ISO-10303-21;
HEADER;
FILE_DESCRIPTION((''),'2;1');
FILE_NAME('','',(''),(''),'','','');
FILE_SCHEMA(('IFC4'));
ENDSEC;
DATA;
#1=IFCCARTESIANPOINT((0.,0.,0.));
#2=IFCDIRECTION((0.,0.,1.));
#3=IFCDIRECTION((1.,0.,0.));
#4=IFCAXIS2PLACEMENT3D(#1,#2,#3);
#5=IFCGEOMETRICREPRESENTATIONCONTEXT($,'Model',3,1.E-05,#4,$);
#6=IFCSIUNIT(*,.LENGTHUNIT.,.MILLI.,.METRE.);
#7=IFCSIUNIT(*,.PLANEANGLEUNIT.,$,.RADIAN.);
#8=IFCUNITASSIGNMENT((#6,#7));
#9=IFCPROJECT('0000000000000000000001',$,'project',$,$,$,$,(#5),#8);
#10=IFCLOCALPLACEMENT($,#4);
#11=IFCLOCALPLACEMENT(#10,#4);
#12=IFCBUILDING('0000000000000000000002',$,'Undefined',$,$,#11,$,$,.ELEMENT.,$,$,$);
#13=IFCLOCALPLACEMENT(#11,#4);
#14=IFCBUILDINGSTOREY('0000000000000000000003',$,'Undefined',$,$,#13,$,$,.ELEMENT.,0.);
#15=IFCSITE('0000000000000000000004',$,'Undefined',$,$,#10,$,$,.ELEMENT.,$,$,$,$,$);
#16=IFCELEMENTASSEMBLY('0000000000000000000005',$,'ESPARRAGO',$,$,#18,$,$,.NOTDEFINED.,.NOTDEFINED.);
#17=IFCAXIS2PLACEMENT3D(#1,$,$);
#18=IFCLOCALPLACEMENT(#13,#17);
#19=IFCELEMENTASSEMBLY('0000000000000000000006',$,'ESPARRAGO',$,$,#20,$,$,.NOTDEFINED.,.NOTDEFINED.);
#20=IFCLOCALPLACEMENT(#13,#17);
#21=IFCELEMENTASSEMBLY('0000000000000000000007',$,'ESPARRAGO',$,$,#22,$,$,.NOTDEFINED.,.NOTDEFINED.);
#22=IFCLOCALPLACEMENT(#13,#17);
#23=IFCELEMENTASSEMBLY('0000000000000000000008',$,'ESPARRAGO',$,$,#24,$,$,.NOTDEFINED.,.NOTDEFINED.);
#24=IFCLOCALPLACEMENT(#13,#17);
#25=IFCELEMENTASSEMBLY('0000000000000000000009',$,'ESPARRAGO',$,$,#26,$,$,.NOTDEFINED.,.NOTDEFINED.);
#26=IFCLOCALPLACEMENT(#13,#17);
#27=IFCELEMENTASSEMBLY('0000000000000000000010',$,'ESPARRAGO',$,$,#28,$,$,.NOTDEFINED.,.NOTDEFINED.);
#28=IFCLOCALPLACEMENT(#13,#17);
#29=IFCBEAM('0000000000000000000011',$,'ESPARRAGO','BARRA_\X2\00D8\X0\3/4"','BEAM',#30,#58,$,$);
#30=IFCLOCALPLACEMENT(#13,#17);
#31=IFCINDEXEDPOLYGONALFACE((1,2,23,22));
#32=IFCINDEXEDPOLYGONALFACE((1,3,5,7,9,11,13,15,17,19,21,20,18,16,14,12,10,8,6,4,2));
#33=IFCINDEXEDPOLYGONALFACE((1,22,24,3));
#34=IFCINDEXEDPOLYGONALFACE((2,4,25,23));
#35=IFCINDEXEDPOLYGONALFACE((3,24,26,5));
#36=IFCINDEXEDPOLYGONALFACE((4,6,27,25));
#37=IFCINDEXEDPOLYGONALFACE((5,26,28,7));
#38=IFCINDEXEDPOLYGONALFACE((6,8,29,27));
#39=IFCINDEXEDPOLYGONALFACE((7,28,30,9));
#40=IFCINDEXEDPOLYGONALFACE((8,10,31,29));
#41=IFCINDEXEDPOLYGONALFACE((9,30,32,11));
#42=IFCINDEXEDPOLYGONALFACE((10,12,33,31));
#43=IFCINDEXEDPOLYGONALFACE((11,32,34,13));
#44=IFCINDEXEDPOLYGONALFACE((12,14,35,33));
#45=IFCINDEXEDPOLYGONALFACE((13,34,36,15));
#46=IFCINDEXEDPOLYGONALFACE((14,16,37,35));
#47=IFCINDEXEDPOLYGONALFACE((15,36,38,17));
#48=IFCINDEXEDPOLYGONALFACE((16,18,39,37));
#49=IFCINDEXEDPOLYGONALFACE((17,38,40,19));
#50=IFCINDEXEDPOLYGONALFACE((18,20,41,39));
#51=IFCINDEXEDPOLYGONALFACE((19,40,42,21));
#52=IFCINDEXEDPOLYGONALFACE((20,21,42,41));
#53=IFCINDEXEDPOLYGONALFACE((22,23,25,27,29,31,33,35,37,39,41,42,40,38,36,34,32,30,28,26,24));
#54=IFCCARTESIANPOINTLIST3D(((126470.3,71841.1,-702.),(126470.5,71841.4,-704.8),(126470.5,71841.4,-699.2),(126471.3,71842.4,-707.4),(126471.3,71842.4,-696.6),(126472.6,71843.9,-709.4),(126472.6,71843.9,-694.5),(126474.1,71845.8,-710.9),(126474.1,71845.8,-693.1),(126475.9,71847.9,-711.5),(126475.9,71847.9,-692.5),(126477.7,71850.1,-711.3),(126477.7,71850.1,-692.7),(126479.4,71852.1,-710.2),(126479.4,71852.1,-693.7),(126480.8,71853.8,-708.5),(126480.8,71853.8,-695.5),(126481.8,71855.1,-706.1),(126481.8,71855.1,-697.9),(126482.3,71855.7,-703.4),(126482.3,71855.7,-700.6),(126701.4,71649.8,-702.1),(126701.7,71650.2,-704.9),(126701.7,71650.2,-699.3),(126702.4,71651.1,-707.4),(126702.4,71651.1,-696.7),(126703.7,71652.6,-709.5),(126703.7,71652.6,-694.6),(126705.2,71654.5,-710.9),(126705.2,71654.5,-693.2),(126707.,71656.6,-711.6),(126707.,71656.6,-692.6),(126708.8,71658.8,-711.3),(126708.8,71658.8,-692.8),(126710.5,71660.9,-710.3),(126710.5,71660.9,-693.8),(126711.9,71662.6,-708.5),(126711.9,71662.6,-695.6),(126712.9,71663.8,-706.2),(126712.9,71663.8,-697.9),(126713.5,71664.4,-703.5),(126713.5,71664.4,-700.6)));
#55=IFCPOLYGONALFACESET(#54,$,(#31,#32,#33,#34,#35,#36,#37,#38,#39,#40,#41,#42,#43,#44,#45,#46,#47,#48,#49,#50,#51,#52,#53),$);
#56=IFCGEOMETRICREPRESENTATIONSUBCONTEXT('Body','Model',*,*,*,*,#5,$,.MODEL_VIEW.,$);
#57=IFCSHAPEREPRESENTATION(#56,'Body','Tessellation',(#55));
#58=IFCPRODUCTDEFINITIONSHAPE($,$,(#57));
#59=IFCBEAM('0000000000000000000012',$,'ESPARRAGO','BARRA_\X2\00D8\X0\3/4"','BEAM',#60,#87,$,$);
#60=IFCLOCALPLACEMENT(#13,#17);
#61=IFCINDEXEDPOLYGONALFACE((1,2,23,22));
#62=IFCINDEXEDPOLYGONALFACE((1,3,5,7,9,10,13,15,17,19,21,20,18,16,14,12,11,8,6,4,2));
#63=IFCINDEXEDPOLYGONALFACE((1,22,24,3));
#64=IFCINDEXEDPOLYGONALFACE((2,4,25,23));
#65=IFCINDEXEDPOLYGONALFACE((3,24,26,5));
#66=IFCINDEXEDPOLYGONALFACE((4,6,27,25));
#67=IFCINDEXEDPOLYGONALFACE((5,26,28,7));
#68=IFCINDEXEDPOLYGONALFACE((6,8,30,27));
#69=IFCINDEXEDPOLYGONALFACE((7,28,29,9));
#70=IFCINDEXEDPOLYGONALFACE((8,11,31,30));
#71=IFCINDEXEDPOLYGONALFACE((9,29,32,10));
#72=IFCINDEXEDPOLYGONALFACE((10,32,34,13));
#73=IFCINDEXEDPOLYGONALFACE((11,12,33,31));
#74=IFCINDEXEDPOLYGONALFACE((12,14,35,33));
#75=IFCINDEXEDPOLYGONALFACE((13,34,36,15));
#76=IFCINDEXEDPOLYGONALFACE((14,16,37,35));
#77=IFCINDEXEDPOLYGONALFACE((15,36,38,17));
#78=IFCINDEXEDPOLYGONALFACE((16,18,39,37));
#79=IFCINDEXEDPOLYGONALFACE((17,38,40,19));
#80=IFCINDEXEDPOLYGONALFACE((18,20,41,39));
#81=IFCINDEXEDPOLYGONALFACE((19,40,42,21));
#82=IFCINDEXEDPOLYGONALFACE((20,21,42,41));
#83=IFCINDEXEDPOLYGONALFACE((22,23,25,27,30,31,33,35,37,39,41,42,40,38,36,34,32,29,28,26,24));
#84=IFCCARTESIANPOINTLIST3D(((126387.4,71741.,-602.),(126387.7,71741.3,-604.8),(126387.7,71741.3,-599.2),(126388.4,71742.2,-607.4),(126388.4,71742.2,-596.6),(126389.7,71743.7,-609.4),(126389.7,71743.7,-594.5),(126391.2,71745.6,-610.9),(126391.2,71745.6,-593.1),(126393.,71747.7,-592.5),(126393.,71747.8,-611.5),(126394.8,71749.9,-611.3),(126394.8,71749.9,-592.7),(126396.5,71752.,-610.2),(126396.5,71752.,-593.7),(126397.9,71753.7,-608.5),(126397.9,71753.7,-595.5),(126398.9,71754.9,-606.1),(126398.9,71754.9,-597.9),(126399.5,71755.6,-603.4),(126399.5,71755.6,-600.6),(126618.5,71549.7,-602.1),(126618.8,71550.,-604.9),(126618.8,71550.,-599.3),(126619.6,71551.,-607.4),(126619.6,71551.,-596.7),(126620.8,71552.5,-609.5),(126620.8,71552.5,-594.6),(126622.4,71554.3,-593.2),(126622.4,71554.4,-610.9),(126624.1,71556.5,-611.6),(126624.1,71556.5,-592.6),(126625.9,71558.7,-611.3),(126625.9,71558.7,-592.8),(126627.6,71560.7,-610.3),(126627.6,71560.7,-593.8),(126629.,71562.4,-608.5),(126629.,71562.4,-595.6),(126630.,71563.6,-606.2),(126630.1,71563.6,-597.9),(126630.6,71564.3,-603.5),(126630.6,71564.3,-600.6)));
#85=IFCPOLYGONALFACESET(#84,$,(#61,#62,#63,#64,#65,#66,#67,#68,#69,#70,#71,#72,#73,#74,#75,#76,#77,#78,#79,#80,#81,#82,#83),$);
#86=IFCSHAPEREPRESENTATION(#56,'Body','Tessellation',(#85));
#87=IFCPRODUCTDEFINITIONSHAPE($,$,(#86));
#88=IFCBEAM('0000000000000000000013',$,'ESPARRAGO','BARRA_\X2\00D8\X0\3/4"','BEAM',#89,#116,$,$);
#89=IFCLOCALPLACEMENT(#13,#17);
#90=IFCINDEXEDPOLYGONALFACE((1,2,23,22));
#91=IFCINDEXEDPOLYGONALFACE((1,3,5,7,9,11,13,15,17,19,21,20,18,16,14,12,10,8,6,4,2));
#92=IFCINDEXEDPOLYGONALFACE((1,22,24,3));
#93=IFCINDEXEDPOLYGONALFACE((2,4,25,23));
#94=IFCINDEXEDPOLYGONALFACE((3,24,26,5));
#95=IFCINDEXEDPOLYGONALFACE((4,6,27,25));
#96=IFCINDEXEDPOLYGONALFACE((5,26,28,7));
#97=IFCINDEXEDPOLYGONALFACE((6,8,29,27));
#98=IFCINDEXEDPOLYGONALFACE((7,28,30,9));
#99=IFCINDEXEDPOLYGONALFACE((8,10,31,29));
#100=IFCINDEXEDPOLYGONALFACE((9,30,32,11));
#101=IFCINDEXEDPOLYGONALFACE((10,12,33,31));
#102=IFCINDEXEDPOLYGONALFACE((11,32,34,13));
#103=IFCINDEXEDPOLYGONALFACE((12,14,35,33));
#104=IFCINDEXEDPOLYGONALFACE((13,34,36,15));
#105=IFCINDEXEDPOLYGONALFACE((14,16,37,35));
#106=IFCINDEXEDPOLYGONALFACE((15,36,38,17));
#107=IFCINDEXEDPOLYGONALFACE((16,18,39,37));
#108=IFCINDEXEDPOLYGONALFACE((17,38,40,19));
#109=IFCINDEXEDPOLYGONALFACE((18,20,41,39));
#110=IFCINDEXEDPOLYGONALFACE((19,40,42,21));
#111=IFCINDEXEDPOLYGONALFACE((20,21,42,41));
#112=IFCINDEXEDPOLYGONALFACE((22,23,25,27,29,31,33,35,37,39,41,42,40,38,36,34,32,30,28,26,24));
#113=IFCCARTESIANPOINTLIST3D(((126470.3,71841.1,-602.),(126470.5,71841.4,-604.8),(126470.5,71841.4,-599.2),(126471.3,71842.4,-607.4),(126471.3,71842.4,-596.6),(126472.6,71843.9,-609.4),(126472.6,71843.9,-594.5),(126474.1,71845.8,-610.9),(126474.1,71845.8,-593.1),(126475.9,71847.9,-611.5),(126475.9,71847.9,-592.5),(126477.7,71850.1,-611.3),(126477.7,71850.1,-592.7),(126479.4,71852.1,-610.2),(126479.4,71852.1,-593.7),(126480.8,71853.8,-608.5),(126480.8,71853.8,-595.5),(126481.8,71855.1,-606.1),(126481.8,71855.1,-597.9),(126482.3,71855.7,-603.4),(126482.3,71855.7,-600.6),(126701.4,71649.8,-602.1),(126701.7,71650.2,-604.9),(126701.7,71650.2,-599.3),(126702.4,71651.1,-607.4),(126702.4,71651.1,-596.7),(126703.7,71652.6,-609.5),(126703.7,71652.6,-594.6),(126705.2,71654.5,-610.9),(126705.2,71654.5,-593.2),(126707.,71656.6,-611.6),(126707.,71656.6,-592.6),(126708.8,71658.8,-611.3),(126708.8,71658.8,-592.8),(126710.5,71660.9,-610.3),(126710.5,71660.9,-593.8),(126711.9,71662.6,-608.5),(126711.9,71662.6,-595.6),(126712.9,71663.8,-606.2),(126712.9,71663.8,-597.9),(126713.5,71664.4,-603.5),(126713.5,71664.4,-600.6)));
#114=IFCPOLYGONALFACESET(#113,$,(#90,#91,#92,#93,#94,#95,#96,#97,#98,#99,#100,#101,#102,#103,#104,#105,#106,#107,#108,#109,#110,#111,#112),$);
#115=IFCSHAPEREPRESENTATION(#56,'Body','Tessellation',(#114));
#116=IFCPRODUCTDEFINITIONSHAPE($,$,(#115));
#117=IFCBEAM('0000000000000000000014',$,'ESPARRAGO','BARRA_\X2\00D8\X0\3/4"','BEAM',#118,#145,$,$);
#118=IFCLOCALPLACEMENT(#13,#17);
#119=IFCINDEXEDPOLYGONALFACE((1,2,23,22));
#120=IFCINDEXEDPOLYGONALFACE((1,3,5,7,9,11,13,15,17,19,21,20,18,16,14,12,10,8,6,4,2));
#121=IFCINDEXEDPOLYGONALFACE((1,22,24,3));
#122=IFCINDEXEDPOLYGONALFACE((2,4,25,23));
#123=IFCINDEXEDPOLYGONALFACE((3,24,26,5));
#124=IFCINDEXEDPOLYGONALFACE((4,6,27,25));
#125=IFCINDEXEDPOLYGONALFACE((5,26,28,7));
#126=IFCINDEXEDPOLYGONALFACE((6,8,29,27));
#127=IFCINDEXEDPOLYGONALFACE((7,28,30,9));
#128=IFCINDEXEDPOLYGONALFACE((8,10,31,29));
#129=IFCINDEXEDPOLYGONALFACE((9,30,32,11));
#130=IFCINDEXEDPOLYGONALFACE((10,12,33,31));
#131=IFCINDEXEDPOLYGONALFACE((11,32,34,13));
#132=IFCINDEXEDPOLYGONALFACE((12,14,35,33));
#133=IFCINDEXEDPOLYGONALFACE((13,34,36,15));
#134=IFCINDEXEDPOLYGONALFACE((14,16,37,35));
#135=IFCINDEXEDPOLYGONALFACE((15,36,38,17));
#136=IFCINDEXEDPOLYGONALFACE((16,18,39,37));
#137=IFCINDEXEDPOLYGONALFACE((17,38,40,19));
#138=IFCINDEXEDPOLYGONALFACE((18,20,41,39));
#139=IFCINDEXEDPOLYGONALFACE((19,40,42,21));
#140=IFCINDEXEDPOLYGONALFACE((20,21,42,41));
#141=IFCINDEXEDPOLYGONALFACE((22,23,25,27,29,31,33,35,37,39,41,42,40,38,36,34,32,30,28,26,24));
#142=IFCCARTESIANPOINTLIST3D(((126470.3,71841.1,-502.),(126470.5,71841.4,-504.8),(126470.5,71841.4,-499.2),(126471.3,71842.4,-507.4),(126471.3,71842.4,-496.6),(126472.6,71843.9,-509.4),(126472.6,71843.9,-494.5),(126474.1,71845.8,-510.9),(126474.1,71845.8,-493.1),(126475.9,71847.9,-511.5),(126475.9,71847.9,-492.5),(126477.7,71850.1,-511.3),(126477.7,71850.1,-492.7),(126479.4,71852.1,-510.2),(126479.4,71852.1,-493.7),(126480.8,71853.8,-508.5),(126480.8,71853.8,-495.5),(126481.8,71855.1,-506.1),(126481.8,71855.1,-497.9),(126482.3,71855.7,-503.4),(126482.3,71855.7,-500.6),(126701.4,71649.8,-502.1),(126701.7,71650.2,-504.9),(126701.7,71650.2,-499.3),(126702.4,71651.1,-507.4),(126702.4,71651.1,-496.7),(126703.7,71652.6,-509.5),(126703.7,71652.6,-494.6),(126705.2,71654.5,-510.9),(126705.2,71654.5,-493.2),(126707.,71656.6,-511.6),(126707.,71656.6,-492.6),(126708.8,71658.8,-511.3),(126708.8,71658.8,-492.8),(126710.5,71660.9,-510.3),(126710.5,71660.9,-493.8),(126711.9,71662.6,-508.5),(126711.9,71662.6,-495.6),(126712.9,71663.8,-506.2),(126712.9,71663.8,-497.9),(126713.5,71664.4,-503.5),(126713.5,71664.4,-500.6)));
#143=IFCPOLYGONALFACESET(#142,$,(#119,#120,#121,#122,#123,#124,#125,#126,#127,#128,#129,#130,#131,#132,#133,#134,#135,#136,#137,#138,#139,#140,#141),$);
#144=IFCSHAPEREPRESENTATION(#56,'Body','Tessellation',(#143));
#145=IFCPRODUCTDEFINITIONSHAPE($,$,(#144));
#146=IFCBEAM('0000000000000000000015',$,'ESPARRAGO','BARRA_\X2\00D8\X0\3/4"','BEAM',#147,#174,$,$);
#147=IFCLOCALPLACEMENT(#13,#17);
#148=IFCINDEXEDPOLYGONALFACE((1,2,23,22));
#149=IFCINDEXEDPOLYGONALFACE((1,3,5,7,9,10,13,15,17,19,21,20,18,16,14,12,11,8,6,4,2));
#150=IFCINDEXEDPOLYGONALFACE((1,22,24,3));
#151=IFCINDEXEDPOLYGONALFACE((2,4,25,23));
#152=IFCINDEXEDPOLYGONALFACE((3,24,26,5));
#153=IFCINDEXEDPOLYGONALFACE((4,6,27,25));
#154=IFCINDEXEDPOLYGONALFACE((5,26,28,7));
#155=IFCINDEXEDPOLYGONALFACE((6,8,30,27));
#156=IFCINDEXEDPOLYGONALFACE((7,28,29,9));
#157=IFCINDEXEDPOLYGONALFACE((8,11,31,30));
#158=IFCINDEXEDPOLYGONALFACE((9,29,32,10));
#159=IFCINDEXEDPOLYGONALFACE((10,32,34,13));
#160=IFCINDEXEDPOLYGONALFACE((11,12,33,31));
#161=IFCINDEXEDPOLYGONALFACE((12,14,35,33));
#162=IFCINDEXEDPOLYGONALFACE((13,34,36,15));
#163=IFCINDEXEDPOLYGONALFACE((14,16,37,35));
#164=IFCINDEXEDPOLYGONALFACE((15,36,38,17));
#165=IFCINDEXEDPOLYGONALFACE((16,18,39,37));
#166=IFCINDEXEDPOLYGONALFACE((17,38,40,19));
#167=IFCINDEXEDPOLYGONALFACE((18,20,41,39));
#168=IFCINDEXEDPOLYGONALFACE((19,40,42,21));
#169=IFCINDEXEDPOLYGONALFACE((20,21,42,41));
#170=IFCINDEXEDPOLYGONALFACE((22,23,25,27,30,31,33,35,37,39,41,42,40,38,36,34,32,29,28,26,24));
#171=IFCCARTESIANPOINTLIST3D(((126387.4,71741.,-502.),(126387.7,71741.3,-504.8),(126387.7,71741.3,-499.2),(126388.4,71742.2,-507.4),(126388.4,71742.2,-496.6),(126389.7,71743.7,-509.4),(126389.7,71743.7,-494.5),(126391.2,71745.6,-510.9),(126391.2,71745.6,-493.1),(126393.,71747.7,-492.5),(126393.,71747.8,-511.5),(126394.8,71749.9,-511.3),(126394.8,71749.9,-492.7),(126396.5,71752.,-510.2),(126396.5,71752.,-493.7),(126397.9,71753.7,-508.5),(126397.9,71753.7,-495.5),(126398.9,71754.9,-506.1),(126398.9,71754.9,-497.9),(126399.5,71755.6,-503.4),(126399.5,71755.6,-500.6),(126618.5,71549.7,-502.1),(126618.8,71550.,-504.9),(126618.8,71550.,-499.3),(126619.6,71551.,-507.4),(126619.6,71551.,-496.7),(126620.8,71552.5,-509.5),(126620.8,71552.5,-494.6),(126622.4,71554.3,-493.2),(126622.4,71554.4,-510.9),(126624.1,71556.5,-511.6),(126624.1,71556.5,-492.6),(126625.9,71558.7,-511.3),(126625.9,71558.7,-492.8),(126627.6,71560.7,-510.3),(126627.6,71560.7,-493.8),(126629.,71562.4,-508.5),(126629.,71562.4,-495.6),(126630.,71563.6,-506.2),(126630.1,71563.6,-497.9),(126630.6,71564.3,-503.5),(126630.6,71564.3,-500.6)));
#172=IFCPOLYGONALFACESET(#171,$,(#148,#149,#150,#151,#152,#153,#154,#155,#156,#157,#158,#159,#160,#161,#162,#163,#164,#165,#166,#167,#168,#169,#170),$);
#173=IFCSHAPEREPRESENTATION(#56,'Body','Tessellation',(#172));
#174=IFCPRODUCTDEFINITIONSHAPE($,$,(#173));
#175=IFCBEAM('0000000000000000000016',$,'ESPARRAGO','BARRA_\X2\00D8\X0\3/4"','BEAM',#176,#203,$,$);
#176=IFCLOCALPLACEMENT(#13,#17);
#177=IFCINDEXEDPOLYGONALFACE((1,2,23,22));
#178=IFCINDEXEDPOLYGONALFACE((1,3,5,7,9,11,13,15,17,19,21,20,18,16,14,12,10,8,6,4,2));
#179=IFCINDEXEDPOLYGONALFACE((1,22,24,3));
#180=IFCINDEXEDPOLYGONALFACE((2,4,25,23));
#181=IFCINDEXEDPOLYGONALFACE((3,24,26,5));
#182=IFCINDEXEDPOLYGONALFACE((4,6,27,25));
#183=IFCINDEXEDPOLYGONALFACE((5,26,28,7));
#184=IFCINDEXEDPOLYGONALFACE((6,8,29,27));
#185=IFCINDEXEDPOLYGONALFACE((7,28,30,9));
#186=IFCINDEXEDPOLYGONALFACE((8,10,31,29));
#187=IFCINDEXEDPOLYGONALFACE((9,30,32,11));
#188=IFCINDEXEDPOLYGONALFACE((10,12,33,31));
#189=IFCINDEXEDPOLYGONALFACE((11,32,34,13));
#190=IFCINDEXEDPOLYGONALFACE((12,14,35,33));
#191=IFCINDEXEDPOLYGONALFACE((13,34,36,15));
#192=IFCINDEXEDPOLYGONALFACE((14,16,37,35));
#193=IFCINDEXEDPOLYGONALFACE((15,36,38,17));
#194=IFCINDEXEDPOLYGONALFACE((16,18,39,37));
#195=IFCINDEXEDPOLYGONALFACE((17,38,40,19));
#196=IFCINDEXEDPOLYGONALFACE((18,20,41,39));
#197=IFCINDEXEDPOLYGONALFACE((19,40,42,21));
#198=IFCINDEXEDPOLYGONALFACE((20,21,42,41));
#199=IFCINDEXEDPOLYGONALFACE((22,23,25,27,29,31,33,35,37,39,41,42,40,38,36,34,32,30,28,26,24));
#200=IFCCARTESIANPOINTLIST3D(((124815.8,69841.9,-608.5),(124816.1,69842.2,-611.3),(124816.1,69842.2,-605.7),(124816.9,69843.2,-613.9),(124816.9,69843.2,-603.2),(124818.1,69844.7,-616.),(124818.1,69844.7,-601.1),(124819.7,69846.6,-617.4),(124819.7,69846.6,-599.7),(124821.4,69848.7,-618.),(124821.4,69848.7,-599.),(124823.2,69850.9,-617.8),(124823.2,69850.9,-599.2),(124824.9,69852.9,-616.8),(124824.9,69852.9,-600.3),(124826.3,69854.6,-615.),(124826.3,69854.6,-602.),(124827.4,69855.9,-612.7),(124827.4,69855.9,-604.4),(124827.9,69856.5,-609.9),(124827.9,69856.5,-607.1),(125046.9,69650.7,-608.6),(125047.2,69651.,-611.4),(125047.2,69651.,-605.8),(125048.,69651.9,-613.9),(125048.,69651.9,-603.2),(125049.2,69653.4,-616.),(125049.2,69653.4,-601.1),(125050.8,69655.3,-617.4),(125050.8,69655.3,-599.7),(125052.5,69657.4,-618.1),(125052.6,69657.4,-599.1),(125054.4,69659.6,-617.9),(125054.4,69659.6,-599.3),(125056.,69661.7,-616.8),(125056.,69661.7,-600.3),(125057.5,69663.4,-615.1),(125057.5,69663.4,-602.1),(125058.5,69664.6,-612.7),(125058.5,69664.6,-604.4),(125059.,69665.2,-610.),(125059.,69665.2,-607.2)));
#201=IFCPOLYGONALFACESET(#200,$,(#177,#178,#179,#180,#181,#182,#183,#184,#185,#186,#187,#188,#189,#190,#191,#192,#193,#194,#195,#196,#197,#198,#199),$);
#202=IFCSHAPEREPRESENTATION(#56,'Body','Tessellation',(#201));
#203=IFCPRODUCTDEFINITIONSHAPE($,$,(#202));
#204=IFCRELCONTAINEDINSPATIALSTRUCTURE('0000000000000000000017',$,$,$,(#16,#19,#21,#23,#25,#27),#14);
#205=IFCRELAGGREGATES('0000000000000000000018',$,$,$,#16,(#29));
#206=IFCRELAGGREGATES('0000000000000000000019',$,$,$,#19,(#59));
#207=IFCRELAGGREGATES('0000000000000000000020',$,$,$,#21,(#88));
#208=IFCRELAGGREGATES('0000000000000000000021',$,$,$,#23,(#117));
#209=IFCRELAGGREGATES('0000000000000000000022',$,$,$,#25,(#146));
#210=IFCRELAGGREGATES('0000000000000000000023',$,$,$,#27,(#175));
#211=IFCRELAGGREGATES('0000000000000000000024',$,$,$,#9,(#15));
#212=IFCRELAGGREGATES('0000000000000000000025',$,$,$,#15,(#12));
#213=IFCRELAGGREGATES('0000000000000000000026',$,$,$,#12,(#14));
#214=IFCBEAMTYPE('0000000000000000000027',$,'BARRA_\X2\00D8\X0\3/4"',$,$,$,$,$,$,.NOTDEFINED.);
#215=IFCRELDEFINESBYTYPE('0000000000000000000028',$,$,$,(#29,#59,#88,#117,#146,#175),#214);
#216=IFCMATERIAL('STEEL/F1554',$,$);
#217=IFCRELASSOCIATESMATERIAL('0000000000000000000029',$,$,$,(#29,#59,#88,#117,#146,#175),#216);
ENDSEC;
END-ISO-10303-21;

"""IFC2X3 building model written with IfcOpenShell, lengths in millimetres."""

from ifc_helpers import new_model, si_unit, frame, origin_with_axes, origin_2d_with_axis, place, context, subcontext, project, spatial, circle, extrude, material, type_object, element, aggregate, save


model = new_model("IFC2X3")

# Units and contexts
model_context = context("Model", 3, precision=1e-05, world=origin_with_axes())
body_context = subcontext(model_context, "Body", "Model", "MODEL_VIEW")
ifc_project = project(units=[si_unit("LENGTHUNIT", "METRE", prefix="MILLI"), si_unit("PLANEANGLEUNIT", "RADIAN")], contexts=[model_context])

# Site, building, storey
site_placement = place(None, origin_with_axes())
site = spatial("IfcSite", under=ifc_project, at=site_placement, Name="Undefined", CompositionType="ELEMENT")
building_placement = place(site_placement, origin_with_axes())
building = spatial("IfcBuilding", under=site, at=building_placement, Name="Undefined", CompositionType="ELEMENT")
storey_placement = place(building_placement, origin_with_axes())
storey = spatial("IfcBuildingStorey", under=building, at=storey_placement, Name="Undefined", CompositionType="ELEMENT", Elevation=0.0)

# Element assemblies
assembly_1_placement = place(storey_placement, origin_with_axes())
assembly_1 = element("IfcElementAssembly", 1, at=assembly_1_placement, inside=storey, Name="ESPARRAGO", AssemblyPlace="NOTDEFINED", PredefinedType="NOTDEFINED")
assembly_2_placement = place(storey_placement, origin_with_axes())
assembly_2 = element("IfcElementAssembly", 2, at=assembly_2_placement, inside=storey, Name="ESPARRAGO", AssemblyPlace="NOTDEFINED", PredefinedType="NOTDEFINED")
assembly_3_placement = place(storey_placement, origin_with_axes())
assembly_3 = element("IfcElementAssembly", 3, at=assembly_3_placement, inside=storey, Name="ESPARRAGO", AssemblyPlace="NOTDEFINED", PredefinedType="NOTDEFINED")
assembly_4_placement = place(storey_placement, origin_with_axes())
assembly_4 = element("IfcElementAssembly", 4, at=assembly_4_placement, inside=storey, Name="ESPARRAGO", AssemblyPlace="NOTDEFINED", PredefinedType="NOTDEFINED")
assembly_5_placement = place(storey_placement, origin_with_axes())
assembly_5 = element("IfcElementAssembly", 5, at=assembly_5_placement, inside=storey, Name="ESPARRAGO", AssemblyPlace="NOTDEFINED", PredefinedType="NOTDEFINED")
assembly_6_placement = place(storey_placement, origin_with_axes())
assembly_6 = element("IfcElementAssembly", 6, at=assembly_6_placement, inside=storey, Name="ESPARRAGO", AssemblyPlace="NOTDEFINED", PredefinedType="NOTDEFINED")

# Beams
ifc_material_1 = material(Name="STEEL/F1554")
beam_type_1 = type_object("IfcBeamType", Name="BARRA_Ø3/4\"", PredefinedType="NOTDEFINED")
beam_1_placement = place(assembly_1_placement, frame((126476.3, 71848.5, -702.0), z_axis=(0.000162, -0.000134, 1.0), x_axis=(0.770403, -0.637558, -0.000211)))
beam_1 = element("IfcBeam", 7, at=beam_1_placement, type_object=beam_type_1, material=ifc_material_1, Name="ESPARRAGO", Description="BARRA_Ø3/4\"", ObjectType="BEAM", context=body_context, shape_type="SweptSolid", body=[
    extrude(circle(Radius=9.5, at=origin_2d_with_axis()), frame((300.0, 0.0, 0.0), z_axis=(-1.0, 0.0, 0.0), x_axis=(0.0, -1.0, 0.0)), (0.0, 0.0, 1.0), 300.0),
])
aggregate(assembly_1, [beam_1])
beam_2_placement = place(assembly_2_placement, frame((126393.5, 71748.3, -602.0), z_axis=(0.000162, -0.000134, 1.0), x_axis=(0.770403, -0.637558, -0.000211)))
beam_2 = element("IfcBeam", 8, at=beam_2_placement, type_object=beam_type_1, material=ifc_material_1, Name="ESPARRAGO", Description="BARRA_Ø3/4\"", ObjectType="BEAM", context=body_context, shape_type="SweptSolid", body=[
    extrude(circle(Radius=9.5, at=origin_2d_with_axis()), frame((300.0, 0.0, 0.0), z_axis=(-1.0, 0.0, 0.0), x_axis=(0.0, -1.0, 0.0)), (0.0, 0.0, 1.0), 300.0),
])
aggregate(assembly_2, [beam_2])
beam_3_placement = place(assembly_3_placement, frame((126476.3, 71848.5, -602.0), z_axis=(0.000162, -0.000134, 1.0), x_axis=(0.770403, -0.637558, -0.000211)))
beam_3 = element("IfcBeam", 9, at=beam_3_placement, type_object=beam_type_1, material=ifc_material_1, Name="ESPARRAGO", Description="BARRA_Ø3/4\"", ObjectType="BEAM", context=body_context, shape_type="SweptSolid", body=[
    extrude(circle(Radius=9.5, at=origin_2d_with_axis()), frame((300.0, 0.0, 0.0), z_axis=(-1.0, 0.0, 0.0), x_axis=(0.0, -1.0, 0.0)), (0.0, 0.0, 1.0), 300.0),
])
aggregate(assembly_3, [beam_3])
beam_4_placement = place(assembly_4_placement, frame((126476.3, 71848.5, -502.0), z_axis=(0.000162, -0.000134, 1.0), x_axis=(0.770403, -0.637558, -0.000211)))
beam_4 = element("IfcBeam", 10, at=beam_4_placement, type_object=beam_type_1, material=ifc_material_1, Name="ESPARRAGO", Description="BARRA_Ø3/4\"", ObjectType="BEAM", context=body_context, shape_type="SweptSolid", body=[
    extrude(circle(Radius=9.5, at=origin_2d_with_axis()), frame((300.0, 0.0, 0.0), z_axis=(-1.0, 0.0, 0.0), x_axis=(0.0, -1.0, 0.0)), (0.0, 0.0, 1.0), 300.0),
])
aggregate(assembly_4, [beam_4])
beam_5_placement = place(assembly_5_placement, frame((126393.5, 71748.3, -502.0), z_axis=(0.000162, -0.000134, 1.0), x_axis=(0.770403, -0.637558, -0.000211)))
beam_5 = element("IfcBeam", 11, at=beam_5_placement, type_object=beam_type_1, material=ifc_material_1, Name="ESPARRAGO", Description="BARRA_Ø3/4\"", ObjectType="BEAM", context=body_context, shape_type="SweptSolid", body=[
    extrude(circle(Radius=9.5, at=origin_2d_with_axis()), frame((300.0, 0.0, 0.0), z_axis=(-1.0, 0.0, 0.0), x_axis=(0.0, -1.0, 0.0)), (0.0, 0.0, 1.0), 300.0),
])
aggregate(assembly_5, [beam_5])
beam_6_placement = place(assembly_6_placement, frame((124821.9, 69849.3, -608.5), z_axis=(0.000162, -0.000134, 1.0), x_axis=(0.770403, -0.637558, -0.000211)))
beam_6 = element("IfcBeam", 12, at=beam_6_placement, type_object=beam_type_1, material=ifc_material_1, Name="ESPARRAGO", Description="BARRA_Ø3/4\"", ObjectType="BEAM", context=body_context, shape_type="SweptSolid", body=[
    extrude(circle(Radius=9.5, at=origin_2d_with_axis()), frame((300.0, 0.0, 0.0), z_axis=(-1.0, 0.0, 0.0), x_axis=(0.0, -1.0, 0.0)), (0.0, 0.0, 1.0), 300.0),
])
aggregate(assembly_6, [beam_6])

save(model, "model.ifc")
